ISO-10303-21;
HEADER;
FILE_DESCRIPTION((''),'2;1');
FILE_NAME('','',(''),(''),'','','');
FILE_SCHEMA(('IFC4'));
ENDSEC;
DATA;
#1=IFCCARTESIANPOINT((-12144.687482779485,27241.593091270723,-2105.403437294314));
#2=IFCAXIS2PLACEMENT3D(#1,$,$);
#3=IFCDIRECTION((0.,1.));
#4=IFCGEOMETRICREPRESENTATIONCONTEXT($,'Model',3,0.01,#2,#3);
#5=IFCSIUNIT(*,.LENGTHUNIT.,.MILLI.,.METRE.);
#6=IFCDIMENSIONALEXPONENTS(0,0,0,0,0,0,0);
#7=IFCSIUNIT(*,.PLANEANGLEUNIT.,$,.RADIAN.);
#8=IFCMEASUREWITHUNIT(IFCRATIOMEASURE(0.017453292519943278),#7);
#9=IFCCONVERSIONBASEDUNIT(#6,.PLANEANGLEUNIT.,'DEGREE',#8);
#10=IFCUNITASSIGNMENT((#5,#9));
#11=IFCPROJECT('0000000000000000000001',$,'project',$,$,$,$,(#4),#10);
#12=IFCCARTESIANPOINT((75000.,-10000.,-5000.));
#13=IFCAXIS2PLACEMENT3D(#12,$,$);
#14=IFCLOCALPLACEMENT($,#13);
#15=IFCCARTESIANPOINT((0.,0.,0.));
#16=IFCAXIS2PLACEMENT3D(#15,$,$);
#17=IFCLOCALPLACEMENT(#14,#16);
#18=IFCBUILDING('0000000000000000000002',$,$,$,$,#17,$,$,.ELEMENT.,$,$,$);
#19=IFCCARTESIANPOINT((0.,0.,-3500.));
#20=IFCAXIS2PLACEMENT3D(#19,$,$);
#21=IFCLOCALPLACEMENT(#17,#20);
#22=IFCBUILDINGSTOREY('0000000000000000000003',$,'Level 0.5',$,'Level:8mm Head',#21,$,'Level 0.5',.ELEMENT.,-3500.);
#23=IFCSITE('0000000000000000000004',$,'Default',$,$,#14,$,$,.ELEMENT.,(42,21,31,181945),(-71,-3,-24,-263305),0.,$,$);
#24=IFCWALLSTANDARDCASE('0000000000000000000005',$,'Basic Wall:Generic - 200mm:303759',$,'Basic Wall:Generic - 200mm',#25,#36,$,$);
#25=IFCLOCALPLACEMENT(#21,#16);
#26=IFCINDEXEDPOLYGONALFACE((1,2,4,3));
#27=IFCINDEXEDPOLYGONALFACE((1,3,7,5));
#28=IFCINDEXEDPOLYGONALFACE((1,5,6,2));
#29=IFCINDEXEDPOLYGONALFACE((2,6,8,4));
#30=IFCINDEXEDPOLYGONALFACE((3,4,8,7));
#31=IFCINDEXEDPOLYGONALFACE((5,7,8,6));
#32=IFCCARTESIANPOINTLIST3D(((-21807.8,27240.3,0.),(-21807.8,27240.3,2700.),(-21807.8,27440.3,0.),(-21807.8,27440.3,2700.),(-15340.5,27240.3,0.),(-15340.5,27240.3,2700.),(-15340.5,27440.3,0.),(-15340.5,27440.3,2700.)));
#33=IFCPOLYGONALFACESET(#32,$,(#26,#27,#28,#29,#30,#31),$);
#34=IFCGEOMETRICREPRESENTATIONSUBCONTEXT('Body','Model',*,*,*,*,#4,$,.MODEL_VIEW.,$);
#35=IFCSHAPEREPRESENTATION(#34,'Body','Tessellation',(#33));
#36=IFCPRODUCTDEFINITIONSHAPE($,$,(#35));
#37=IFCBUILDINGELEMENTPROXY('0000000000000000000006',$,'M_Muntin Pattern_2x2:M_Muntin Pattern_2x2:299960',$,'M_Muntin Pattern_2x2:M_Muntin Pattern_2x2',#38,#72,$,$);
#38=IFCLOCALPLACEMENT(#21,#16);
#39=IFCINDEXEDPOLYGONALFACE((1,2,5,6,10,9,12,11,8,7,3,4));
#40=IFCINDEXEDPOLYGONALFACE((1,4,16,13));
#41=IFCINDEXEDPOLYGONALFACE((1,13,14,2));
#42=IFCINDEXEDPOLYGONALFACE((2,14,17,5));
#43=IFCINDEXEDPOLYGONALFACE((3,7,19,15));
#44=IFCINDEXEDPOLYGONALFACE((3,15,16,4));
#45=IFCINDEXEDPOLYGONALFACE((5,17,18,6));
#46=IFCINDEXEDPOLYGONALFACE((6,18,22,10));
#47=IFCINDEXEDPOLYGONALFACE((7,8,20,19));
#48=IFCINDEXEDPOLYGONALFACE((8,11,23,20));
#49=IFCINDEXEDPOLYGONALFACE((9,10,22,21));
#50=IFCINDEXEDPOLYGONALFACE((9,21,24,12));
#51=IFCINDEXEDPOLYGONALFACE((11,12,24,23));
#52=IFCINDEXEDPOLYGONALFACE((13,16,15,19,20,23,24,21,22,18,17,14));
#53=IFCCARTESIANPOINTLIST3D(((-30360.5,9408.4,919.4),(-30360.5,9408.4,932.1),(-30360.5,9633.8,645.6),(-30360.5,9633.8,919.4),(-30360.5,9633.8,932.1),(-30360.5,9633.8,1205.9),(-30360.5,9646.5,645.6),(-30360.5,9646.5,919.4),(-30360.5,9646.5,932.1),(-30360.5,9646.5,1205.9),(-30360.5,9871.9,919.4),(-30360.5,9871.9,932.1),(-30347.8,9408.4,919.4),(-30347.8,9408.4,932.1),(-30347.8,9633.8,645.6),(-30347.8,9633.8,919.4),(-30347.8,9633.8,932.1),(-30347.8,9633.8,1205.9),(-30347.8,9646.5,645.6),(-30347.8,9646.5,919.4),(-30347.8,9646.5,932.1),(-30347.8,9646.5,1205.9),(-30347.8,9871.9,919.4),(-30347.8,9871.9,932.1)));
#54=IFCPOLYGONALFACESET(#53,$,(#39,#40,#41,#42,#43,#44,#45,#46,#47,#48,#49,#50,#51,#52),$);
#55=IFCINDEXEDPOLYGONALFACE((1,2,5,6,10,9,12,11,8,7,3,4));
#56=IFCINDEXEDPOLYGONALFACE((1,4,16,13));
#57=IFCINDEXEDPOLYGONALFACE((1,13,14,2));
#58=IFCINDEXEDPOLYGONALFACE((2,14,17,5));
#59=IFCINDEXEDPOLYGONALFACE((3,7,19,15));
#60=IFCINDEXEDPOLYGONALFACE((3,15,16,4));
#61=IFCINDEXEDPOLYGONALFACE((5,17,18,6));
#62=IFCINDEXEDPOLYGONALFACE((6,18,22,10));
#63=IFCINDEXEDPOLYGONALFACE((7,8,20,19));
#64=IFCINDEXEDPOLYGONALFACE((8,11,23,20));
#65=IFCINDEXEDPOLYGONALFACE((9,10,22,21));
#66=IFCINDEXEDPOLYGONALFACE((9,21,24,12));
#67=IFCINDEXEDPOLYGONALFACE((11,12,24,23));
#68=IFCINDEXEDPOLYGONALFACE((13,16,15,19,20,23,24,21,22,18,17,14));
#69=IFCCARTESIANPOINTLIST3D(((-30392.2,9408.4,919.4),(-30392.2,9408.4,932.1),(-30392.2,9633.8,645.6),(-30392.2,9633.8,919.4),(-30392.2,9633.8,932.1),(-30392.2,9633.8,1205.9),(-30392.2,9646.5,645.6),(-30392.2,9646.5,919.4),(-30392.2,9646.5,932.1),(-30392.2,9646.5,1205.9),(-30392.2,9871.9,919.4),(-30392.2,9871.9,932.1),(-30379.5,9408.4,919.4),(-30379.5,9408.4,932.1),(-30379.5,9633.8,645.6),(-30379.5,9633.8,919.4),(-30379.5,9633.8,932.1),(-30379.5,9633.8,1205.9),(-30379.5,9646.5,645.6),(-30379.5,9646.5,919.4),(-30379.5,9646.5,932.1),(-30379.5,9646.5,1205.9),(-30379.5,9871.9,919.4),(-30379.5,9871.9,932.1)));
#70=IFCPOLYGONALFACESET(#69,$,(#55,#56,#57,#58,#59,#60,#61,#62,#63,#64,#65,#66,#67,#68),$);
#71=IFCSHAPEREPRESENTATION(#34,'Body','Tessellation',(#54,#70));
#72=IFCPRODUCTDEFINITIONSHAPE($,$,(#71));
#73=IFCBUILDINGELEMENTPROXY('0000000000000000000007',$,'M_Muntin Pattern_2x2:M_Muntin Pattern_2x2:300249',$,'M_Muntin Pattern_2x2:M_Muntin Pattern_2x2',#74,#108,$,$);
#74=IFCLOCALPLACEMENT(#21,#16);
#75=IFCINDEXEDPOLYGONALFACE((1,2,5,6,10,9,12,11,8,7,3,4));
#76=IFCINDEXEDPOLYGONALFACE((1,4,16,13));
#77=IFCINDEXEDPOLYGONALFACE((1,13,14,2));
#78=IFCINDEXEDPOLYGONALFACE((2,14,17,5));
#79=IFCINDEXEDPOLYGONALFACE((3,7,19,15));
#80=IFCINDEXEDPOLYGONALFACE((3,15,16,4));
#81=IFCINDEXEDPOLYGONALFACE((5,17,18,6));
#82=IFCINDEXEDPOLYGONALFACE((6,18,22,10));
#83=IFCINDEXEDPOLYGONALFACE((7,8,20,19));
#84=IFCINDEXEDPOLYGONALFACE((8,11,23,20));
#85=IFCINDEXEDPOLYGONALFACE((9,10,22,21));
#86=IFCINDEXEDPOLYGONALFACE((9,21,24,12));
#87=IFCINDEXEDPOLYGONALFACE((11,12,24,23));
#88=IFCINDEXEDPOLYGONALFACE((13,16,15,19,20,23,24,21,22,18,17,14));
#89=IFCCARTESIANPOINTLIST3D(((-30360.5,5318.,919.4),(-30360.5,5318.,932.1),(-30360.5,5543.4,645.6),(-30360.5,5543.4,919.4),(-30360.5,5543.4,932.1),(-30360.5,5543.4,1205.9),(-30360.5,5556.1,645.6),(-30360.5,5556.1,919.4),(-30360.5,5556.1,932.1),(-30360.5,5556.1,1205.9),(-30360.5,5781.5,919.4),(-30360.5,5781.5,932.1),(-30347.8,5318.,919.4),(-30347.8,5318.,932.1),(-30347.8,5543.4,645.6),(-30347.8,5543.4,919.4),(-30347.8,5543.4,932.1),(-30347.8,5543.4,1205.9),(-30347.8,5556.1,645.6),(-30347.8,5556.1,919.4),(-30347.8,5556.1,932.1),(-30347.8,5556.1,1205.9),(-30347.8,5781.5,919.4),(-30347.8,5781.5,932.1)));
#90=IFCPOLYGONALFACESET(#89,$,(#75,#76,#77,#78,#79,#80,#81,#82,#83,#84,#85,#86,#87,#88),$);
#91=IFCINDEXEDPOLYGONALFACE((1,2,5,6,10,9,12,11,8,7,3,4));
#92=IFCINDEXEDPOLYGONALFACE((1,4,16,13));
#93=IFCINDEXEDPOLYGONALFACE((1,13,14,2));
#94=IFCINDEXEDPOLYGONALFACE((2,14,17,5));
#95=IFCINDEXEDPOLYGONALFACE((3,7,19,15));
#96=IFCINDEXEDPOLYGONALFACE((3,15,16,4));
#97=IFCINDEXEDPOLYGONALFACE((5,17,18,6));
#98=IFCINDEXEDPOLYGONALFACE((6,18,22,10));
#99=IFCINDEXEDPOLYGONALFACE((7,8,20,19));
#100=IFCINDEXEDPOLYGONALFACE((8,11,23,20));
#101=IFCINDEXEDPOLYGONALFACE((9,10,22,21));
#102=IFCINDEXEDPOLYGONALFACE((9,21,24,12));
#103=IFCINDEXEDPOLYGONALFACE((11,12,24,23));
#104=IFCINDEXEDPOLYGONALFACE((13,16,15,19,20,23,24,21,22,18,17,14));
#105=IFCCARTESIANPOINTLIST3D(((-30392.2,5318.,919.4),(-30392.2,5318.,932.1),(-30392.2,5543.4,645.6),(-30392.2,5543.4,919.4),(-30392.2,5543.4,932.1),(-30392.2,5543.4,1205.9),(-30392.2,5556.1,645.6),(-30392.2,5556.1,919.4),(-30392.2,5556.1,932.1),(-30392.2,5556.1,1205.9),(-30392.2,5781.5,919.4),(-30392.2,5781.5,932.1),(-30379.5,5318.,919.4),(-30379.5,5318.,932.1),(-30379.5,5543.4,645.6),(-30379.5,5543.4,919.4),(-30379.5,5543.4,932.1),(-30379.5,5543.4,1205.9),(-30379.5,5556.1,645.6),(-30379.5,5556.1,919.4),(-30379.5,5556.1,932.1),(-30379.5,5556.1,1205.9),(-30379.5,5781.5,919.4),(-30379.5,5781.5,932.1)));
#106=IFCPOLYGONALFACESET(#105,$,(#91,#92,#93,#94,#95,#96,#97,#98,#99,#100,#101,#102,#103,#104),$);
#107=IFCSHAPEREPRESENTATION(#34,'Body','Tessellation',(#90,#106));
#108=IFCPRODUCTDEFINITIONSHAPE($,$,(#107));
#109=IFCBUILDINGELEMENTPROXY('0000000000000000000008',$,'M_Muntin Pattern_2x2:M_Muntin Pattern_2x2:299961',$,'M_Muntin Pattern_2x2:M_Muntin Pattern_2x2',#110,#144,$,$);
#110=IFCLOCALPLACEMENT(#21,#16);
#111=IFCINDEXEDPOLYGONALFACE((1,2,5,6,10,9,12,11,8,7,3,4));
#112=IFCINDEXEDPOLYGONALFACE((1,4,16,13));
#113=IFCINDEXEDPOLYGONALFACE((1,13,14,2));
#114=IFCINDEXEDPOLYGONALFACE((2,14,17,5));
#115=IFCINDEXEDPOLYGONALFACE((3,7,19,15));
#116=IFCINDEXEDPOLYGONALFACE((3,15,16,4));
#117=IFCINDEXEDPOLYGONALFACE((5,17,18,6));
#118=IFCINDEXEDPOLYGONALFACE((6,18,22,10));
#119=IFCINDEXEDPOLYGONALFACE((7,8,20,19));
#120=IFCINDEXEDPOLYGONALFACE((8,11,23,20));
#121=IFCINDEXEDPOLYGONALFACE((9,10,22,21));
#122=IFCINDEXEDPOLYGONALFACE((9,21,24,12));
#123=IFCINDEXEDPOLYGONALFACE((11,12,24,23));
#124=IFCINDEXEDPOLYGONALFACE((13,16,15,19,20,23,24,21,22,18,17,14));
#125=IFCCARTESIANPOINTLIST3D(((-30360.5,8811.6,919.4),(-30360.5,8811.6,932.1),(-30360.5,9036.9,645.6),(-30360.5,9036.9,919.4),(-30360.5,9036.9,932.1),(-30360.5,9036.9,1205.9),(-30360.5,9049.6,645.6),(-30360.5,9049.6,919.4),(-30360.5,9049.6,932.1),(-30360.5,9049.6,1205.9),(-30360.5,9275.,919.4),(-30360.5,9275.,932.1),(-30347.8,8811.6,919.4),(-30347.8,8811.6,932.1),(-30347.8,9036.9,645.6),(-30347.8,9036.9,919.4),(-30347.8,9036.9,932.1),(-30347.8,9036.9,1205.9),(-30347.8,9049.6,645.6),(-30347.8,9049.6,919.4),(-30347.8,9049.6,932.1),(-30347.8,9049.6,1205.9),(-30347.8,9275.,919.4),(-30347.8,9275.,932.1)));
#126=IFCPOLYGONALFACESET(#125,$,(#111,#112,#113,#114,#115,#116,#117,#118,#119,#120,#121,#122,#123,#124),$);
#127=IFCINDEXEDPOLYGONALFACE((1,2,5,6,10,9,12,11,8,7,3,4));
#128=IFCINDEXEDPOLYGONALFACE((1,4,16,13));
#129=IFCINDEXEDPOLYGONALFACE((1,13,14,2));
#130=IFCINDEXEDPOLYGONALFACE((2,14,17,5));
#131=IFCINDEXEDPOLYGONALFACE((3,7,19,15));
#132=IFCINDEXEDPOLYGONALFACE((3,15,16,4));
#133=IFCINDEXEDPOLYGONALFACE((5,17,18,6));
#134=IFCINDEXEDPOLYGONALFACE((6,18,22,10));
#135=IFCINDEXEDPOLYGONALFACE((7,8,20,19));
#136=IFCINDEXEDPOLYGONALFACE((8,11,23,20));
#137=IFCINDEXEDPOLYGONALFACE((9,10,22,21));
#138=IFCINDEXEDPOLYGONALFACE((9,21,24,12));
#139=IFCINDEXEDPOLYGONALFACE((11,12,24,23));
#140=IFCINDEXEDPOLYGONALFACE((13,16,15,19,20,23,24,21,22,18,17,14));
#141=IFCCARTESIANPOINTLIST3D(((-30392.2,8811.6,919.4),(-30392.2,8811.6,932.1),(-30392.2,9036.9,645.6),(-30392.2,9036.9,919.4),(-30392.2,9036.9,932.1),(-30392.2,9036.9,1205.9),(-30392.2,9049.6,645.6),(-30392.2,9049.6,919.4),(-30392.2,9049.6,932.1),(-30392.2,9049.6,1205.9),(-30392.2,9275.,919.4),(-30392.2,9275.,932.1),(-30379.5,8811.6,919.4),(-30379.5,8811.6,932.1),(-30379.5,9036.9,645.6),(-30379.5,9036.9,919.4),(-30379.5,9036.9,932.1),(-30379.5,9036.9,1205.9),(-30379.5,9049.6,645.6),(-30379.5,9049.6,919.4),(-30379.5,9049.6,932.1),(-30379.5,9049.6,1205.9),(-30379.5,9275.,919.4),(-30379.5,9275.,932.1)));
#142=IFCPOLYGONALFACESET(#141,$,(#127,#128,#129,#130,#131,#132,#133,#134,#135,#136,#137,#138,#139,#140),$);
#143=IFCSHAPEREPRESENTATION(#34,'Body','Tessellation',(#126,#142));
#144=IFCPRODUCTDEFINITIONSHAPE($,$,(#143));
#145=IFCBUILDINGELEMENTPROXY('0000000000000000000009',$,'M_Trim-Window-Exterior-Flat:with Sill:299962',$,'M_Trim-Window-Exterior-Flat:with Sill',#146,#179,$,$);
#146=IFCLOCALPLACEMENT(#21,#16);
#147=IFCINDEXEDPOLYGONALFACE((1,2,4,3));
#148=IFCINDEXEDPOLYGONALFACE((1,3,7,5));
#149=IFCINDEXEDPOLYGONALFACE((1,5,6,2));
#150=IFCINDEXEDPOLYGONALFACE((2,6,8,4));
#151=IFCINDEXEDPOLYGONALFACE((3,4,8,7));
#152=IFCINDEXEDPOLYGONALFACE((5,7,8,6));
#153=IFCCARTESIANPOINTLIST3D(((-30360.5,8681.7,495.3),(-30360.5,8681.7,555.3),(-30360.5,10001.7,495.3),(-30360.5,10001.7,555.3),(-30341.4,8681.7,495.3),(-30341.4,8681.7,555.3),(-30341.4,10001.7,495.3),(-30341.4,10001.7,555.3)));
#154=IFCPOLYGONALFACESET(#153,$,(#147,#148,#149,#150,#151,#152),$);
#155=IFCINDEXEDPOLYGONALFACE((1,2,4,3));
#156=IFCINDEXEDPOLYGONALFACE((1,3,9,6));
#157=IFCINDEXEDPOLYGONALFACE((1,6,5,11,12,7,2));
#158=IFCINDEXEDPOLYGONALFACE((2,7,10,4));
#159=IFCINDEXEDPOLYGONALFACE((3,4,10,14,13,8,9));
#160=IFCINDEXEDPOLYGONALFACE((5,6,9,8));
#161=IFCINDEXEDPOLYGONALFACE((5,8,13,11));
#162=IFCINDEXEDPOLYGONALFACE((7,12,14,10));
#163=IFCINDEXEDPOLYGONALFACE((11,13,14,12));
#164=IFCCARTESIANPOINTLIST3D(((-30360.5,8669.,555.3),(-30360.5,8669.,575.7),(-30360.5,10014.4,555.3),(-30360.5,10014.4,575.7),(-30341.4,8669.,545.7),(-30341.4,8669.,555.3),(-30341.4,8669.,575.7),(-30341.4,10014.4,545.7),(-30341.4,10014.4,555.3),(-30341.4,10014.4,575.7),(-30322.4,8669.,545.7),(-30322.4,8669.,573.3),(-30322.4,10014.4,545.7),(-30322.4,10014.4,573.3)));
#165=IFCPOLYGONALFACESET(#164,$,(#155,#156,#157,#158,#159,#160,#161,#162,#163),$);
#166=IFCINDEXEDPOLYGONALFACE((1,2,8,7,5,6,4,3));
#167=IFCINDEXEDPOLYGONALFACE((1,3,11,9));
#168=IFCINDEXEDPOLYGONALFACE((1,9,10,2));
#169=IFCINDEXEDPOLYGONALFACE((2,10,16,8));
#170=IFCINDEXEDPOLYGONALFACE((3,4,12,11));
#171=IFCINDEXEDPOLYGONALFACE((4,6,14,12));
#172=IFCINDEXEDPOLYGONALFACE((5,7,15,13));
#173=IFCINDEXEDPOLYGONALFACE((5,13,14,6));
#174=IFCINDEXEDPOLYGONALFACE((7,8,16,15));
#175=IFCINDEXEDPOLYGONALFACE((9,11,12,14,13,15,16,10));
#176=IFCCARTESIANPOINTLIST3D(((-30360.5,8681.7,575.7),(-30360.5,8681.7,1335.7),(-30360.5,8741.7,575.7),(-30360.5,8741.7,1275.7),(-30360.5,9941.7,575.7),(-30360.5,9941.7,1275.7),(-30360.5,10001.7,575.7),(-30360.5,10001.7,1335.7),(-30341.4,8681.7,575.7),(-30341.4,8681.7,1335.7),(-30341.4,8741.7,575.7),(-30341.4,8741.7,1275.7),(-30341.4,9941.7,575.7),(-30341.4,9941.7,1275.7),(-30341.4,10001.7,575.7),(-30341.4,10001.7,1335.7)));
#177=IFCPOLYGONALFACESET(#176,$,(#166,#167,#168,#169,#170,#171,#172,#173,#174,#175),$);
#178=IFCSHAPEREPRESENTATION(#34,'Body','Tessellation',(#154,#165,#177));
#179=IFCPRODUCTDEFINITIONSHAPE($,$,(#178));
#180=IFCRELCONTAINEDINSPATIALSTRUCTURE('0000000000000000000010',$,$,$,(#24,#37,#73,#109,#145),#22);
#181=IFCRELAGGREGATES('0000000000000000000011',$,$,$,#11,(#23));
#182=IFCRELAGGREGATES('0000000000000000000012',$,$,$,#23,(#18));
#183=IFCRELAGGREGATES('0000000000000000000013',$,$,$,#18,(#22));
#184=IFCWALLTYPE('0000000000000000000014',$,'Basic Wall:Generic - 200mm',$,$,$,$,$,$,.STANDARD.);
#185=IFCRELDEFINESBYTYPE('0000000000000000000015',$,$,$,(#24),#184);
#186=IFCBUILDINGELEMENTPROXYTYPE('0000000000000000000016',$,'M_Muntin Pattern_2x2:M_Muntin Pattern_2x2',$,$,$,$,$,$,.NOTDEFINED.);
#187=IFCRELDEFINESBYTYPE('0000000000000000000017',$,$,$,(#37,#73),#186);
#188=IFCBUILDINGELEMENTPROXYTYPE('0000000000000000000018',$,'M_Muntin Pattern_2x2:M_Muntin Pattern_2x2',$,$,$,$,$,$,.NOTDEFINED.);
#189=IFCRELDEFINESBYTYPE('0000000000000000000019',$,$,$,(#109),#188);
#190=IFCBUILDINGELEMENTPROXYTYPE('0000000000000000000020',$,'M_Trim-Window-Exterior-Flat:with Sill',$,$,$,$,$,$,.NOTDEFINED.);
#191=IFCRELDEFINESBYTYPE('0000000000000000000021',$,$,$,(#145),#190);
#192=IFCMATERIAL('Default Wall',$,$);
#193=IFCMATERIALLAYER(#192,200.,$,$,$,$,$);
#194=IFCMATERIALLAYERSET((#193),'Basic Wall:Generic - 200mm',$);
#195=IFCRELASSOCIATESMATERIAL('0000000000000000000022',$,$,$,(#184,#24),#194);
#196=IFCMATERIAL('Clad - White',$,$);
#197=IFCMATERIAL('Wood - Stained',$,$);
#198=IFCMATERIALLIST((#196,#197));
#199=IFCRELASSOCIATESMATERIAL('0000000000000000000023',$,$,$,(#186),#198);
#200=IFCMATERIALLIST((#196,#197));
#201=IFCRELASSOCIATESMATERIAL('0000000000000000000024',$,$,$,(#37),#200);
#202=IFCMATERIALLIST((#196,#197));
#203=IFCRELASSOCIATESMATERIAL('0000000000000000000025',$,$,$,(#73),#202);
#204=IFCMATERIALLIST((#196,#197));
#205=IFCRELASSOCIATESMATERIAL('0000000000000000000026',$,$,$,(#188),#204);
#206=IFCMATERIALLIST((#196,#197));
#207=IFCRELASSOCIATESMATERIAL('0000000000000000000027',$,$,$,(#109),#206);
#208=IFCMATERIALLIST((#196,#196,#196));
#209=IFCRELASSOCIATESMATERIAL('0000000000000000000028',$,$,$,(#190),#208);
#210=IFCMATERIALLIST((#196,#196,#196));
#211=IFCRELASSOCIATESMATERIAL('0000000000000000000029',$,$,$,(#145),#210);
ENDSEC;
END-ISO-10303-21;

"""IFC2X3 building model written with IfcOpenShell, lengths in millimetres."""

from ifc_helpers import new_model, entity, si_unit, converted_unit, direction, frame, frame_2d, origin, place, context, subcontext, project, spatial, polyline, rectangle, outline, extrude, source, transform, mapped, material, material_list, layer, layer_set, layer_usage, type_object, type_shapes, element, save


model = new_model("IFC2X3")

# Units and contexts
model_context = context("Model", 3, precision=0.01, world=frame((-12144.687482779485, 27241.593091270723, -2105.403437294314)), true_north=direction((0.0, 1.0)))
body_context = subcontext(model_context, "Body", "Model", "MODEL_VIEW")
ifc_project = project(units=[si_unit("LENGTHUNIT", "METRE", prefix="MILLI"), converted_unit("PLANEANGLEUNIT", "DEGREE", entity("IfcRatioMeasure", 0.017453292519943278), si_unit("PLANEANGLEUNIT", "RADIAN"), dimensions=[0, 0, 0, 0, 0, 0, 0])], contexts=[model_context])

# Site, building, storey
site_placement = place(None, frame((75000.0, -10000.0, -5000.0)))
site = spatial("IfcSite", under=ifc_project, at=site_placement, Name="Default", CompositionType="ELEMENT", RefLatitude=(42, 21, 31, 181945), RefLongitude=(-71, -3, -24, -263305), RefElevation=0.0)
building_placement = place(site_placement, origin())
building = spatial("IfcBuilding", under=site, at=building_placement, CompositionType="ELEMENT")
storey_placement = place(building_placement, frame((0.0, 0.0, -3500.0)))
storey = spatial("IfcBuildingStorey", under=building, at=storey_placement, Name="Level 0.5", ObjectType="Level:8mm Head", LongName="Level 0.5", CompositionType="ELEMENT", Elevation=-3500.0)

# Shared definitions
ifc_material_1 = material(Name="Default Wall")
ifc_layer_1 = layer(ifc_material_1, 200.0)
ifc_layer_set_1 = layer_set([ifc_layer_1], Name="Basic Wall:Generic - 200mm")
wall_type_1 = type_object("IfcWallType", Name="Basic Wall:Generic - 200mm", PredefinedType="STANDARD", material=ifc_layer_set_1)

# Wall
ifc_layer_usage_1 = layer_usage(ifc_layer_set_1, "AXIS2", "NEGATIVE", 100.0)
wall_1_placement = place(storey_placement, frame((-15340.5, 27340.3, 0.0), z_axis=(0.0, 0.0, 1.0), x_axis=(-1.0, 0.0, 0.0)))
element("IfcWallStandardCase", 1, at=wall_1_placement, inside=storey, type_object=wall_type_1, material=ifc_layer_usage_1, Name="Basic Wall:Generic - 200mm:303759", ObjectType="Basic Wall:Generic - 200mm", context=body_context, shape_type="SweptSolid", body=[
    extrude(rectangle(XDim=6467.3, YDim=200.0, at=frame_2d((3233.6, 0.0), x_axis=(-1.0, 0.0))), origin(), (0.0, 0.0, 1.0), 2700.0),
])

# Building element proxies
ifc_material_2 = material(Name="Clad - White")
ifc_material_3 = material(Name="Wood - Stained")
ifc_material_list_1 = material_list([ifc_material_2, ifc_material_3])
ifc_material_list_2 = material_list([ifc_material_2, ifc_material_3])
building_element_proxy_type_1 = type_object("IfcBuildingElementProxyType", Name="M_Muntin Pattern_2x2:M_Muntin Pattern_2x2", PredefinedType="NOTDEFINED", material=ifc_material_list_2)
shared_shape_1 = source(origin(), body_context, "Body", "SweptSolid", [
    extrude(outline(polyline([(6.4, -6.4), (280.1, -6.4), (280.1, 6.3), (6.4, 6.3), (6.4, 231.7), (-6.3, 231.7), (-6.3, 6.3), (-280.2, 6.3), (-280.2, -6.4), (-6.3, -6.4), (-6.3, -231.7), (6.4, -231.7), (6.4, -6.4)])), frame((0.0, 9.5, 280.1), z_axis=(0.0, 1.0, 0.0), x_axis=(0.0, 0.0, 1.0)), (0.0, 0.0, 1.0), 12.7),
    extrude(outline(polyline([(6.4, -6.4), (280.2, -6.4), (280.2, 6.3), (6.4, 6.3), (6.4, 231.7), (-6.3, 231.7), (-6.3, 6.3), (-280.2, 6.3), (-280.2, -6.4), (-6.3, -6.4), (-6.3, -231.7), (6.4, -231.7), (6.4, -6.4)])), frame((0.0, -22.2, 280.2), z_axis=(0.0, 1.0, 0.0), x_axis=(0.0, 0.0, 1.0)), (0.0, 0.0, 1.0), 12.7),
])
type_shapes(building_element_proxy_type_1, [shared_shape_1])
proxy_1_placement = place(storey_placement, frame((-30370.0, 9640.1, 645.6), z_axis=(0.0, 0.0, 1.0), x_axis=(0.0, -1.0, 0.0)))
element("IfcBuildingElementProxy", 2, at=proxy_1_placement, inside=storey, type_object=building_element_proxy_type_1, material=ifc_material_list_1, Name="M_Muntin Pattern_2x2:M_Muntin Pattern_2x2:299960", ObjectType="M_Muntin Pattern_2x2:M_Muntin Pattern_2x2", context=body_context, shape_type="MappedRepresentation", body=[
    mapped(shared_shape_1, transform((0.0, 0.0, 0.0), scale=1.0)),
])
ifc_material_list_3 = material_list([ifc_material_2, ifc_material_3])
proxy_2_placement = place(storey_placement, frame((-30370.0, 5549.7, 645.6), z_axis=(0.0, 0.0, 1.0), x_axis=(0.0, -1.0, 0.0)))
element("IfcBuildingElementProxy", 3, at=proxy_2_placement, inside=storey, type_object=building_element_proxy_type_1, material=ifc_material_list_3, Name="M_Muntin Pattern_2x2:M_Muntin Pattern_2x2:300249", ObjectType="M_Muntin Pattern_2x2:M_Muntin Pattern_2x2", context=body_context, shape_type="MappedRepresentation", body=[
    mapped(shared_shape_1, transform((0.0, 0.0, 0.0), scale=1.0)),
])
ifc_material_list_4 = material_list([ifc_material_2, ifc_material_3])
ifc_material_list_5 = material_list([ifc_material_2, ifc_material_3])
building_element_proxy_type_2 = type_object("IfcBuildingElementProxyType", Name="M_Muntin Pattern_2x2:M_Muntin Pattern_2x2", PredefinedType="NOTDEFINED", material=ifc_material_list_5)
shared_shape_2 = source(origin(), body_context, "Body", "SweptSolid", [
    extrude(outline(polyline([(6.4, -6.4), (280.1, -6.4), (280.1, 6.3), (6.4, 6.3), (6.4, 231.7), (-6.3, 231.7), (-6.3, 6.3), (-280.2, 6.3), (-280.2, -6.4), (-6.3, -6.4), (-6.3, -231.7), (6.4, -231.7), (6.4, -6.4)])), frame((0.0, -22.2, 280.1), z_axis=(0.0, 1.0, 0.0), x_axis=(0.0, 0.0, 1.0)), (0.0, 0.0, 1.0), 12.7),
    extrude(outline(polyline([(6.4, -6.4), (280.2, -6.4), (280.2, 6.3), (6.4, 6.3), (6.4, 231.7), (-6.3, 231.7), (-6.3, 6.3), (-280.2, 6.3), (-280.2, -6.4), (-6.3, -6.4), (-6.3, -231.7), (6.4, -231.7), (6.4, -6.4)])), frame((0.0, 9.5, 280.2), z_axis=(0.0, 1.0, 0.0), x_axis=(0.0, 0.0, 1.0)), (0.0, 0.0, 1.0), 12.7),
])
type_shapes(building_element_proxy_type_2, [shared_shape_2])
proxy_3_placement = place(storey_placement, frame((-30370.0, 9043.3, 645.6), z_axis=(0.0, 0.0, 1.0), x_axis=(0.0, 1.0, 0.0)))
element("IfcBuildingElementProxy", 4, at=proxy_3_placement, inside=storey, type_object=building_element_proxy_type_2, material=ifc_material_list_4, Name="M_Muntin Pattern_2x2:M_Muntin Pattern_2x2:299961", ObjectType="M_Muntin Pattern_2x2:M_Muntin Pattern_2x2", context=body_context, shape_type="MappedRepresentation", body=[
    mapped(shared_shape_2, transform((0.0, 0.0, 0.0), scale=1.0)),
])
ifc_material_list_6 = material_list([ifc_material_2, ifc_material_2, ifc_material_2])
ifc_material_list_7 = material_list([ifc_material_2, ifc_material_2, ifc_material_2])
building_element_proxy_type_3 = type_object("IfcBuildingElementProxyType", Name="M_Trim-Window-Exterior-Flat:with Sill", PredefinedType="NOTDEFINED", material=ifc_material_list_7)
shared_shape_3 = source(origin(), body_context, "Body", "SweptSolid", [
    extrude(rectangle(XDim=1320.0, YDim=60.0, at=frame_2d((0.0, 0.0), x_axis=(1.0, 0.0))), frame((0.0, -750.4, 0.0), z_axis=(0.0, 0.0, 1.0), x_axis=(-1.0, 0.0, 0.0)), (0.0, 0.0, 1.0), 19.0),
    extrude(outline(polyline([(-19.0, -15.2), (0.0, -15.2), (0.0, -5.7), (19.0, -5.7), (19.0, 14.8), (0.0, 14.8), (-19.0, 12.3), (-19.0, -15.2)])), frame((-672.7, -714.8, 19.0), z_axis=(1.0, 0.0, 0.0), x_axis=(0.0, 0.0, -1.0)), (0.0, 0.0, 1.0), 1345.4),
    extrude(outline(polyline([(-395.0, -660.0), (365.0, -660.0), (365.0, -600.0), (-335.0, -600.0), (-335.0, 600.0), (365.0, 600.0), (365.0, 660.0), (-395.0, 660.0), (-395.0, -660.0)])), frame((0.0, -335.0, 0.0), z_axis=(0.0, 0.0, 1.0), x_axis=(0.0, -1.0, 0.0)), (0.0, 0.0, 1.0), 19.0),
])
type_shapes(building_element_proxy_type_3, [shared_shape_3])
proxy_4_placement = place(storey_placement, frame((-30360.5, 9341.7, 1275.7), z_axis=(1.0, 0.0, 0.0), x_axis=(0.0, 1.0, 0.0)))
element("IfcBuildingElementProxy", 5, at=proxy_4_placement, inside=storey, type_object=building_element_proxy_type_3, material=ifc_material_list_6, Name="M_Trim-Window-Exterior-Flat:with Sill:299962", ObjectType="M_Trim-Window-Exterior-Flat:with Sill", context=body_context, shape_type="MappedRepresentation", body=[
    mapped(shared_shape_3, transform((0.0, 0.0, 0.0), scale=1.0)),
])

save(model, "model.ifc")
